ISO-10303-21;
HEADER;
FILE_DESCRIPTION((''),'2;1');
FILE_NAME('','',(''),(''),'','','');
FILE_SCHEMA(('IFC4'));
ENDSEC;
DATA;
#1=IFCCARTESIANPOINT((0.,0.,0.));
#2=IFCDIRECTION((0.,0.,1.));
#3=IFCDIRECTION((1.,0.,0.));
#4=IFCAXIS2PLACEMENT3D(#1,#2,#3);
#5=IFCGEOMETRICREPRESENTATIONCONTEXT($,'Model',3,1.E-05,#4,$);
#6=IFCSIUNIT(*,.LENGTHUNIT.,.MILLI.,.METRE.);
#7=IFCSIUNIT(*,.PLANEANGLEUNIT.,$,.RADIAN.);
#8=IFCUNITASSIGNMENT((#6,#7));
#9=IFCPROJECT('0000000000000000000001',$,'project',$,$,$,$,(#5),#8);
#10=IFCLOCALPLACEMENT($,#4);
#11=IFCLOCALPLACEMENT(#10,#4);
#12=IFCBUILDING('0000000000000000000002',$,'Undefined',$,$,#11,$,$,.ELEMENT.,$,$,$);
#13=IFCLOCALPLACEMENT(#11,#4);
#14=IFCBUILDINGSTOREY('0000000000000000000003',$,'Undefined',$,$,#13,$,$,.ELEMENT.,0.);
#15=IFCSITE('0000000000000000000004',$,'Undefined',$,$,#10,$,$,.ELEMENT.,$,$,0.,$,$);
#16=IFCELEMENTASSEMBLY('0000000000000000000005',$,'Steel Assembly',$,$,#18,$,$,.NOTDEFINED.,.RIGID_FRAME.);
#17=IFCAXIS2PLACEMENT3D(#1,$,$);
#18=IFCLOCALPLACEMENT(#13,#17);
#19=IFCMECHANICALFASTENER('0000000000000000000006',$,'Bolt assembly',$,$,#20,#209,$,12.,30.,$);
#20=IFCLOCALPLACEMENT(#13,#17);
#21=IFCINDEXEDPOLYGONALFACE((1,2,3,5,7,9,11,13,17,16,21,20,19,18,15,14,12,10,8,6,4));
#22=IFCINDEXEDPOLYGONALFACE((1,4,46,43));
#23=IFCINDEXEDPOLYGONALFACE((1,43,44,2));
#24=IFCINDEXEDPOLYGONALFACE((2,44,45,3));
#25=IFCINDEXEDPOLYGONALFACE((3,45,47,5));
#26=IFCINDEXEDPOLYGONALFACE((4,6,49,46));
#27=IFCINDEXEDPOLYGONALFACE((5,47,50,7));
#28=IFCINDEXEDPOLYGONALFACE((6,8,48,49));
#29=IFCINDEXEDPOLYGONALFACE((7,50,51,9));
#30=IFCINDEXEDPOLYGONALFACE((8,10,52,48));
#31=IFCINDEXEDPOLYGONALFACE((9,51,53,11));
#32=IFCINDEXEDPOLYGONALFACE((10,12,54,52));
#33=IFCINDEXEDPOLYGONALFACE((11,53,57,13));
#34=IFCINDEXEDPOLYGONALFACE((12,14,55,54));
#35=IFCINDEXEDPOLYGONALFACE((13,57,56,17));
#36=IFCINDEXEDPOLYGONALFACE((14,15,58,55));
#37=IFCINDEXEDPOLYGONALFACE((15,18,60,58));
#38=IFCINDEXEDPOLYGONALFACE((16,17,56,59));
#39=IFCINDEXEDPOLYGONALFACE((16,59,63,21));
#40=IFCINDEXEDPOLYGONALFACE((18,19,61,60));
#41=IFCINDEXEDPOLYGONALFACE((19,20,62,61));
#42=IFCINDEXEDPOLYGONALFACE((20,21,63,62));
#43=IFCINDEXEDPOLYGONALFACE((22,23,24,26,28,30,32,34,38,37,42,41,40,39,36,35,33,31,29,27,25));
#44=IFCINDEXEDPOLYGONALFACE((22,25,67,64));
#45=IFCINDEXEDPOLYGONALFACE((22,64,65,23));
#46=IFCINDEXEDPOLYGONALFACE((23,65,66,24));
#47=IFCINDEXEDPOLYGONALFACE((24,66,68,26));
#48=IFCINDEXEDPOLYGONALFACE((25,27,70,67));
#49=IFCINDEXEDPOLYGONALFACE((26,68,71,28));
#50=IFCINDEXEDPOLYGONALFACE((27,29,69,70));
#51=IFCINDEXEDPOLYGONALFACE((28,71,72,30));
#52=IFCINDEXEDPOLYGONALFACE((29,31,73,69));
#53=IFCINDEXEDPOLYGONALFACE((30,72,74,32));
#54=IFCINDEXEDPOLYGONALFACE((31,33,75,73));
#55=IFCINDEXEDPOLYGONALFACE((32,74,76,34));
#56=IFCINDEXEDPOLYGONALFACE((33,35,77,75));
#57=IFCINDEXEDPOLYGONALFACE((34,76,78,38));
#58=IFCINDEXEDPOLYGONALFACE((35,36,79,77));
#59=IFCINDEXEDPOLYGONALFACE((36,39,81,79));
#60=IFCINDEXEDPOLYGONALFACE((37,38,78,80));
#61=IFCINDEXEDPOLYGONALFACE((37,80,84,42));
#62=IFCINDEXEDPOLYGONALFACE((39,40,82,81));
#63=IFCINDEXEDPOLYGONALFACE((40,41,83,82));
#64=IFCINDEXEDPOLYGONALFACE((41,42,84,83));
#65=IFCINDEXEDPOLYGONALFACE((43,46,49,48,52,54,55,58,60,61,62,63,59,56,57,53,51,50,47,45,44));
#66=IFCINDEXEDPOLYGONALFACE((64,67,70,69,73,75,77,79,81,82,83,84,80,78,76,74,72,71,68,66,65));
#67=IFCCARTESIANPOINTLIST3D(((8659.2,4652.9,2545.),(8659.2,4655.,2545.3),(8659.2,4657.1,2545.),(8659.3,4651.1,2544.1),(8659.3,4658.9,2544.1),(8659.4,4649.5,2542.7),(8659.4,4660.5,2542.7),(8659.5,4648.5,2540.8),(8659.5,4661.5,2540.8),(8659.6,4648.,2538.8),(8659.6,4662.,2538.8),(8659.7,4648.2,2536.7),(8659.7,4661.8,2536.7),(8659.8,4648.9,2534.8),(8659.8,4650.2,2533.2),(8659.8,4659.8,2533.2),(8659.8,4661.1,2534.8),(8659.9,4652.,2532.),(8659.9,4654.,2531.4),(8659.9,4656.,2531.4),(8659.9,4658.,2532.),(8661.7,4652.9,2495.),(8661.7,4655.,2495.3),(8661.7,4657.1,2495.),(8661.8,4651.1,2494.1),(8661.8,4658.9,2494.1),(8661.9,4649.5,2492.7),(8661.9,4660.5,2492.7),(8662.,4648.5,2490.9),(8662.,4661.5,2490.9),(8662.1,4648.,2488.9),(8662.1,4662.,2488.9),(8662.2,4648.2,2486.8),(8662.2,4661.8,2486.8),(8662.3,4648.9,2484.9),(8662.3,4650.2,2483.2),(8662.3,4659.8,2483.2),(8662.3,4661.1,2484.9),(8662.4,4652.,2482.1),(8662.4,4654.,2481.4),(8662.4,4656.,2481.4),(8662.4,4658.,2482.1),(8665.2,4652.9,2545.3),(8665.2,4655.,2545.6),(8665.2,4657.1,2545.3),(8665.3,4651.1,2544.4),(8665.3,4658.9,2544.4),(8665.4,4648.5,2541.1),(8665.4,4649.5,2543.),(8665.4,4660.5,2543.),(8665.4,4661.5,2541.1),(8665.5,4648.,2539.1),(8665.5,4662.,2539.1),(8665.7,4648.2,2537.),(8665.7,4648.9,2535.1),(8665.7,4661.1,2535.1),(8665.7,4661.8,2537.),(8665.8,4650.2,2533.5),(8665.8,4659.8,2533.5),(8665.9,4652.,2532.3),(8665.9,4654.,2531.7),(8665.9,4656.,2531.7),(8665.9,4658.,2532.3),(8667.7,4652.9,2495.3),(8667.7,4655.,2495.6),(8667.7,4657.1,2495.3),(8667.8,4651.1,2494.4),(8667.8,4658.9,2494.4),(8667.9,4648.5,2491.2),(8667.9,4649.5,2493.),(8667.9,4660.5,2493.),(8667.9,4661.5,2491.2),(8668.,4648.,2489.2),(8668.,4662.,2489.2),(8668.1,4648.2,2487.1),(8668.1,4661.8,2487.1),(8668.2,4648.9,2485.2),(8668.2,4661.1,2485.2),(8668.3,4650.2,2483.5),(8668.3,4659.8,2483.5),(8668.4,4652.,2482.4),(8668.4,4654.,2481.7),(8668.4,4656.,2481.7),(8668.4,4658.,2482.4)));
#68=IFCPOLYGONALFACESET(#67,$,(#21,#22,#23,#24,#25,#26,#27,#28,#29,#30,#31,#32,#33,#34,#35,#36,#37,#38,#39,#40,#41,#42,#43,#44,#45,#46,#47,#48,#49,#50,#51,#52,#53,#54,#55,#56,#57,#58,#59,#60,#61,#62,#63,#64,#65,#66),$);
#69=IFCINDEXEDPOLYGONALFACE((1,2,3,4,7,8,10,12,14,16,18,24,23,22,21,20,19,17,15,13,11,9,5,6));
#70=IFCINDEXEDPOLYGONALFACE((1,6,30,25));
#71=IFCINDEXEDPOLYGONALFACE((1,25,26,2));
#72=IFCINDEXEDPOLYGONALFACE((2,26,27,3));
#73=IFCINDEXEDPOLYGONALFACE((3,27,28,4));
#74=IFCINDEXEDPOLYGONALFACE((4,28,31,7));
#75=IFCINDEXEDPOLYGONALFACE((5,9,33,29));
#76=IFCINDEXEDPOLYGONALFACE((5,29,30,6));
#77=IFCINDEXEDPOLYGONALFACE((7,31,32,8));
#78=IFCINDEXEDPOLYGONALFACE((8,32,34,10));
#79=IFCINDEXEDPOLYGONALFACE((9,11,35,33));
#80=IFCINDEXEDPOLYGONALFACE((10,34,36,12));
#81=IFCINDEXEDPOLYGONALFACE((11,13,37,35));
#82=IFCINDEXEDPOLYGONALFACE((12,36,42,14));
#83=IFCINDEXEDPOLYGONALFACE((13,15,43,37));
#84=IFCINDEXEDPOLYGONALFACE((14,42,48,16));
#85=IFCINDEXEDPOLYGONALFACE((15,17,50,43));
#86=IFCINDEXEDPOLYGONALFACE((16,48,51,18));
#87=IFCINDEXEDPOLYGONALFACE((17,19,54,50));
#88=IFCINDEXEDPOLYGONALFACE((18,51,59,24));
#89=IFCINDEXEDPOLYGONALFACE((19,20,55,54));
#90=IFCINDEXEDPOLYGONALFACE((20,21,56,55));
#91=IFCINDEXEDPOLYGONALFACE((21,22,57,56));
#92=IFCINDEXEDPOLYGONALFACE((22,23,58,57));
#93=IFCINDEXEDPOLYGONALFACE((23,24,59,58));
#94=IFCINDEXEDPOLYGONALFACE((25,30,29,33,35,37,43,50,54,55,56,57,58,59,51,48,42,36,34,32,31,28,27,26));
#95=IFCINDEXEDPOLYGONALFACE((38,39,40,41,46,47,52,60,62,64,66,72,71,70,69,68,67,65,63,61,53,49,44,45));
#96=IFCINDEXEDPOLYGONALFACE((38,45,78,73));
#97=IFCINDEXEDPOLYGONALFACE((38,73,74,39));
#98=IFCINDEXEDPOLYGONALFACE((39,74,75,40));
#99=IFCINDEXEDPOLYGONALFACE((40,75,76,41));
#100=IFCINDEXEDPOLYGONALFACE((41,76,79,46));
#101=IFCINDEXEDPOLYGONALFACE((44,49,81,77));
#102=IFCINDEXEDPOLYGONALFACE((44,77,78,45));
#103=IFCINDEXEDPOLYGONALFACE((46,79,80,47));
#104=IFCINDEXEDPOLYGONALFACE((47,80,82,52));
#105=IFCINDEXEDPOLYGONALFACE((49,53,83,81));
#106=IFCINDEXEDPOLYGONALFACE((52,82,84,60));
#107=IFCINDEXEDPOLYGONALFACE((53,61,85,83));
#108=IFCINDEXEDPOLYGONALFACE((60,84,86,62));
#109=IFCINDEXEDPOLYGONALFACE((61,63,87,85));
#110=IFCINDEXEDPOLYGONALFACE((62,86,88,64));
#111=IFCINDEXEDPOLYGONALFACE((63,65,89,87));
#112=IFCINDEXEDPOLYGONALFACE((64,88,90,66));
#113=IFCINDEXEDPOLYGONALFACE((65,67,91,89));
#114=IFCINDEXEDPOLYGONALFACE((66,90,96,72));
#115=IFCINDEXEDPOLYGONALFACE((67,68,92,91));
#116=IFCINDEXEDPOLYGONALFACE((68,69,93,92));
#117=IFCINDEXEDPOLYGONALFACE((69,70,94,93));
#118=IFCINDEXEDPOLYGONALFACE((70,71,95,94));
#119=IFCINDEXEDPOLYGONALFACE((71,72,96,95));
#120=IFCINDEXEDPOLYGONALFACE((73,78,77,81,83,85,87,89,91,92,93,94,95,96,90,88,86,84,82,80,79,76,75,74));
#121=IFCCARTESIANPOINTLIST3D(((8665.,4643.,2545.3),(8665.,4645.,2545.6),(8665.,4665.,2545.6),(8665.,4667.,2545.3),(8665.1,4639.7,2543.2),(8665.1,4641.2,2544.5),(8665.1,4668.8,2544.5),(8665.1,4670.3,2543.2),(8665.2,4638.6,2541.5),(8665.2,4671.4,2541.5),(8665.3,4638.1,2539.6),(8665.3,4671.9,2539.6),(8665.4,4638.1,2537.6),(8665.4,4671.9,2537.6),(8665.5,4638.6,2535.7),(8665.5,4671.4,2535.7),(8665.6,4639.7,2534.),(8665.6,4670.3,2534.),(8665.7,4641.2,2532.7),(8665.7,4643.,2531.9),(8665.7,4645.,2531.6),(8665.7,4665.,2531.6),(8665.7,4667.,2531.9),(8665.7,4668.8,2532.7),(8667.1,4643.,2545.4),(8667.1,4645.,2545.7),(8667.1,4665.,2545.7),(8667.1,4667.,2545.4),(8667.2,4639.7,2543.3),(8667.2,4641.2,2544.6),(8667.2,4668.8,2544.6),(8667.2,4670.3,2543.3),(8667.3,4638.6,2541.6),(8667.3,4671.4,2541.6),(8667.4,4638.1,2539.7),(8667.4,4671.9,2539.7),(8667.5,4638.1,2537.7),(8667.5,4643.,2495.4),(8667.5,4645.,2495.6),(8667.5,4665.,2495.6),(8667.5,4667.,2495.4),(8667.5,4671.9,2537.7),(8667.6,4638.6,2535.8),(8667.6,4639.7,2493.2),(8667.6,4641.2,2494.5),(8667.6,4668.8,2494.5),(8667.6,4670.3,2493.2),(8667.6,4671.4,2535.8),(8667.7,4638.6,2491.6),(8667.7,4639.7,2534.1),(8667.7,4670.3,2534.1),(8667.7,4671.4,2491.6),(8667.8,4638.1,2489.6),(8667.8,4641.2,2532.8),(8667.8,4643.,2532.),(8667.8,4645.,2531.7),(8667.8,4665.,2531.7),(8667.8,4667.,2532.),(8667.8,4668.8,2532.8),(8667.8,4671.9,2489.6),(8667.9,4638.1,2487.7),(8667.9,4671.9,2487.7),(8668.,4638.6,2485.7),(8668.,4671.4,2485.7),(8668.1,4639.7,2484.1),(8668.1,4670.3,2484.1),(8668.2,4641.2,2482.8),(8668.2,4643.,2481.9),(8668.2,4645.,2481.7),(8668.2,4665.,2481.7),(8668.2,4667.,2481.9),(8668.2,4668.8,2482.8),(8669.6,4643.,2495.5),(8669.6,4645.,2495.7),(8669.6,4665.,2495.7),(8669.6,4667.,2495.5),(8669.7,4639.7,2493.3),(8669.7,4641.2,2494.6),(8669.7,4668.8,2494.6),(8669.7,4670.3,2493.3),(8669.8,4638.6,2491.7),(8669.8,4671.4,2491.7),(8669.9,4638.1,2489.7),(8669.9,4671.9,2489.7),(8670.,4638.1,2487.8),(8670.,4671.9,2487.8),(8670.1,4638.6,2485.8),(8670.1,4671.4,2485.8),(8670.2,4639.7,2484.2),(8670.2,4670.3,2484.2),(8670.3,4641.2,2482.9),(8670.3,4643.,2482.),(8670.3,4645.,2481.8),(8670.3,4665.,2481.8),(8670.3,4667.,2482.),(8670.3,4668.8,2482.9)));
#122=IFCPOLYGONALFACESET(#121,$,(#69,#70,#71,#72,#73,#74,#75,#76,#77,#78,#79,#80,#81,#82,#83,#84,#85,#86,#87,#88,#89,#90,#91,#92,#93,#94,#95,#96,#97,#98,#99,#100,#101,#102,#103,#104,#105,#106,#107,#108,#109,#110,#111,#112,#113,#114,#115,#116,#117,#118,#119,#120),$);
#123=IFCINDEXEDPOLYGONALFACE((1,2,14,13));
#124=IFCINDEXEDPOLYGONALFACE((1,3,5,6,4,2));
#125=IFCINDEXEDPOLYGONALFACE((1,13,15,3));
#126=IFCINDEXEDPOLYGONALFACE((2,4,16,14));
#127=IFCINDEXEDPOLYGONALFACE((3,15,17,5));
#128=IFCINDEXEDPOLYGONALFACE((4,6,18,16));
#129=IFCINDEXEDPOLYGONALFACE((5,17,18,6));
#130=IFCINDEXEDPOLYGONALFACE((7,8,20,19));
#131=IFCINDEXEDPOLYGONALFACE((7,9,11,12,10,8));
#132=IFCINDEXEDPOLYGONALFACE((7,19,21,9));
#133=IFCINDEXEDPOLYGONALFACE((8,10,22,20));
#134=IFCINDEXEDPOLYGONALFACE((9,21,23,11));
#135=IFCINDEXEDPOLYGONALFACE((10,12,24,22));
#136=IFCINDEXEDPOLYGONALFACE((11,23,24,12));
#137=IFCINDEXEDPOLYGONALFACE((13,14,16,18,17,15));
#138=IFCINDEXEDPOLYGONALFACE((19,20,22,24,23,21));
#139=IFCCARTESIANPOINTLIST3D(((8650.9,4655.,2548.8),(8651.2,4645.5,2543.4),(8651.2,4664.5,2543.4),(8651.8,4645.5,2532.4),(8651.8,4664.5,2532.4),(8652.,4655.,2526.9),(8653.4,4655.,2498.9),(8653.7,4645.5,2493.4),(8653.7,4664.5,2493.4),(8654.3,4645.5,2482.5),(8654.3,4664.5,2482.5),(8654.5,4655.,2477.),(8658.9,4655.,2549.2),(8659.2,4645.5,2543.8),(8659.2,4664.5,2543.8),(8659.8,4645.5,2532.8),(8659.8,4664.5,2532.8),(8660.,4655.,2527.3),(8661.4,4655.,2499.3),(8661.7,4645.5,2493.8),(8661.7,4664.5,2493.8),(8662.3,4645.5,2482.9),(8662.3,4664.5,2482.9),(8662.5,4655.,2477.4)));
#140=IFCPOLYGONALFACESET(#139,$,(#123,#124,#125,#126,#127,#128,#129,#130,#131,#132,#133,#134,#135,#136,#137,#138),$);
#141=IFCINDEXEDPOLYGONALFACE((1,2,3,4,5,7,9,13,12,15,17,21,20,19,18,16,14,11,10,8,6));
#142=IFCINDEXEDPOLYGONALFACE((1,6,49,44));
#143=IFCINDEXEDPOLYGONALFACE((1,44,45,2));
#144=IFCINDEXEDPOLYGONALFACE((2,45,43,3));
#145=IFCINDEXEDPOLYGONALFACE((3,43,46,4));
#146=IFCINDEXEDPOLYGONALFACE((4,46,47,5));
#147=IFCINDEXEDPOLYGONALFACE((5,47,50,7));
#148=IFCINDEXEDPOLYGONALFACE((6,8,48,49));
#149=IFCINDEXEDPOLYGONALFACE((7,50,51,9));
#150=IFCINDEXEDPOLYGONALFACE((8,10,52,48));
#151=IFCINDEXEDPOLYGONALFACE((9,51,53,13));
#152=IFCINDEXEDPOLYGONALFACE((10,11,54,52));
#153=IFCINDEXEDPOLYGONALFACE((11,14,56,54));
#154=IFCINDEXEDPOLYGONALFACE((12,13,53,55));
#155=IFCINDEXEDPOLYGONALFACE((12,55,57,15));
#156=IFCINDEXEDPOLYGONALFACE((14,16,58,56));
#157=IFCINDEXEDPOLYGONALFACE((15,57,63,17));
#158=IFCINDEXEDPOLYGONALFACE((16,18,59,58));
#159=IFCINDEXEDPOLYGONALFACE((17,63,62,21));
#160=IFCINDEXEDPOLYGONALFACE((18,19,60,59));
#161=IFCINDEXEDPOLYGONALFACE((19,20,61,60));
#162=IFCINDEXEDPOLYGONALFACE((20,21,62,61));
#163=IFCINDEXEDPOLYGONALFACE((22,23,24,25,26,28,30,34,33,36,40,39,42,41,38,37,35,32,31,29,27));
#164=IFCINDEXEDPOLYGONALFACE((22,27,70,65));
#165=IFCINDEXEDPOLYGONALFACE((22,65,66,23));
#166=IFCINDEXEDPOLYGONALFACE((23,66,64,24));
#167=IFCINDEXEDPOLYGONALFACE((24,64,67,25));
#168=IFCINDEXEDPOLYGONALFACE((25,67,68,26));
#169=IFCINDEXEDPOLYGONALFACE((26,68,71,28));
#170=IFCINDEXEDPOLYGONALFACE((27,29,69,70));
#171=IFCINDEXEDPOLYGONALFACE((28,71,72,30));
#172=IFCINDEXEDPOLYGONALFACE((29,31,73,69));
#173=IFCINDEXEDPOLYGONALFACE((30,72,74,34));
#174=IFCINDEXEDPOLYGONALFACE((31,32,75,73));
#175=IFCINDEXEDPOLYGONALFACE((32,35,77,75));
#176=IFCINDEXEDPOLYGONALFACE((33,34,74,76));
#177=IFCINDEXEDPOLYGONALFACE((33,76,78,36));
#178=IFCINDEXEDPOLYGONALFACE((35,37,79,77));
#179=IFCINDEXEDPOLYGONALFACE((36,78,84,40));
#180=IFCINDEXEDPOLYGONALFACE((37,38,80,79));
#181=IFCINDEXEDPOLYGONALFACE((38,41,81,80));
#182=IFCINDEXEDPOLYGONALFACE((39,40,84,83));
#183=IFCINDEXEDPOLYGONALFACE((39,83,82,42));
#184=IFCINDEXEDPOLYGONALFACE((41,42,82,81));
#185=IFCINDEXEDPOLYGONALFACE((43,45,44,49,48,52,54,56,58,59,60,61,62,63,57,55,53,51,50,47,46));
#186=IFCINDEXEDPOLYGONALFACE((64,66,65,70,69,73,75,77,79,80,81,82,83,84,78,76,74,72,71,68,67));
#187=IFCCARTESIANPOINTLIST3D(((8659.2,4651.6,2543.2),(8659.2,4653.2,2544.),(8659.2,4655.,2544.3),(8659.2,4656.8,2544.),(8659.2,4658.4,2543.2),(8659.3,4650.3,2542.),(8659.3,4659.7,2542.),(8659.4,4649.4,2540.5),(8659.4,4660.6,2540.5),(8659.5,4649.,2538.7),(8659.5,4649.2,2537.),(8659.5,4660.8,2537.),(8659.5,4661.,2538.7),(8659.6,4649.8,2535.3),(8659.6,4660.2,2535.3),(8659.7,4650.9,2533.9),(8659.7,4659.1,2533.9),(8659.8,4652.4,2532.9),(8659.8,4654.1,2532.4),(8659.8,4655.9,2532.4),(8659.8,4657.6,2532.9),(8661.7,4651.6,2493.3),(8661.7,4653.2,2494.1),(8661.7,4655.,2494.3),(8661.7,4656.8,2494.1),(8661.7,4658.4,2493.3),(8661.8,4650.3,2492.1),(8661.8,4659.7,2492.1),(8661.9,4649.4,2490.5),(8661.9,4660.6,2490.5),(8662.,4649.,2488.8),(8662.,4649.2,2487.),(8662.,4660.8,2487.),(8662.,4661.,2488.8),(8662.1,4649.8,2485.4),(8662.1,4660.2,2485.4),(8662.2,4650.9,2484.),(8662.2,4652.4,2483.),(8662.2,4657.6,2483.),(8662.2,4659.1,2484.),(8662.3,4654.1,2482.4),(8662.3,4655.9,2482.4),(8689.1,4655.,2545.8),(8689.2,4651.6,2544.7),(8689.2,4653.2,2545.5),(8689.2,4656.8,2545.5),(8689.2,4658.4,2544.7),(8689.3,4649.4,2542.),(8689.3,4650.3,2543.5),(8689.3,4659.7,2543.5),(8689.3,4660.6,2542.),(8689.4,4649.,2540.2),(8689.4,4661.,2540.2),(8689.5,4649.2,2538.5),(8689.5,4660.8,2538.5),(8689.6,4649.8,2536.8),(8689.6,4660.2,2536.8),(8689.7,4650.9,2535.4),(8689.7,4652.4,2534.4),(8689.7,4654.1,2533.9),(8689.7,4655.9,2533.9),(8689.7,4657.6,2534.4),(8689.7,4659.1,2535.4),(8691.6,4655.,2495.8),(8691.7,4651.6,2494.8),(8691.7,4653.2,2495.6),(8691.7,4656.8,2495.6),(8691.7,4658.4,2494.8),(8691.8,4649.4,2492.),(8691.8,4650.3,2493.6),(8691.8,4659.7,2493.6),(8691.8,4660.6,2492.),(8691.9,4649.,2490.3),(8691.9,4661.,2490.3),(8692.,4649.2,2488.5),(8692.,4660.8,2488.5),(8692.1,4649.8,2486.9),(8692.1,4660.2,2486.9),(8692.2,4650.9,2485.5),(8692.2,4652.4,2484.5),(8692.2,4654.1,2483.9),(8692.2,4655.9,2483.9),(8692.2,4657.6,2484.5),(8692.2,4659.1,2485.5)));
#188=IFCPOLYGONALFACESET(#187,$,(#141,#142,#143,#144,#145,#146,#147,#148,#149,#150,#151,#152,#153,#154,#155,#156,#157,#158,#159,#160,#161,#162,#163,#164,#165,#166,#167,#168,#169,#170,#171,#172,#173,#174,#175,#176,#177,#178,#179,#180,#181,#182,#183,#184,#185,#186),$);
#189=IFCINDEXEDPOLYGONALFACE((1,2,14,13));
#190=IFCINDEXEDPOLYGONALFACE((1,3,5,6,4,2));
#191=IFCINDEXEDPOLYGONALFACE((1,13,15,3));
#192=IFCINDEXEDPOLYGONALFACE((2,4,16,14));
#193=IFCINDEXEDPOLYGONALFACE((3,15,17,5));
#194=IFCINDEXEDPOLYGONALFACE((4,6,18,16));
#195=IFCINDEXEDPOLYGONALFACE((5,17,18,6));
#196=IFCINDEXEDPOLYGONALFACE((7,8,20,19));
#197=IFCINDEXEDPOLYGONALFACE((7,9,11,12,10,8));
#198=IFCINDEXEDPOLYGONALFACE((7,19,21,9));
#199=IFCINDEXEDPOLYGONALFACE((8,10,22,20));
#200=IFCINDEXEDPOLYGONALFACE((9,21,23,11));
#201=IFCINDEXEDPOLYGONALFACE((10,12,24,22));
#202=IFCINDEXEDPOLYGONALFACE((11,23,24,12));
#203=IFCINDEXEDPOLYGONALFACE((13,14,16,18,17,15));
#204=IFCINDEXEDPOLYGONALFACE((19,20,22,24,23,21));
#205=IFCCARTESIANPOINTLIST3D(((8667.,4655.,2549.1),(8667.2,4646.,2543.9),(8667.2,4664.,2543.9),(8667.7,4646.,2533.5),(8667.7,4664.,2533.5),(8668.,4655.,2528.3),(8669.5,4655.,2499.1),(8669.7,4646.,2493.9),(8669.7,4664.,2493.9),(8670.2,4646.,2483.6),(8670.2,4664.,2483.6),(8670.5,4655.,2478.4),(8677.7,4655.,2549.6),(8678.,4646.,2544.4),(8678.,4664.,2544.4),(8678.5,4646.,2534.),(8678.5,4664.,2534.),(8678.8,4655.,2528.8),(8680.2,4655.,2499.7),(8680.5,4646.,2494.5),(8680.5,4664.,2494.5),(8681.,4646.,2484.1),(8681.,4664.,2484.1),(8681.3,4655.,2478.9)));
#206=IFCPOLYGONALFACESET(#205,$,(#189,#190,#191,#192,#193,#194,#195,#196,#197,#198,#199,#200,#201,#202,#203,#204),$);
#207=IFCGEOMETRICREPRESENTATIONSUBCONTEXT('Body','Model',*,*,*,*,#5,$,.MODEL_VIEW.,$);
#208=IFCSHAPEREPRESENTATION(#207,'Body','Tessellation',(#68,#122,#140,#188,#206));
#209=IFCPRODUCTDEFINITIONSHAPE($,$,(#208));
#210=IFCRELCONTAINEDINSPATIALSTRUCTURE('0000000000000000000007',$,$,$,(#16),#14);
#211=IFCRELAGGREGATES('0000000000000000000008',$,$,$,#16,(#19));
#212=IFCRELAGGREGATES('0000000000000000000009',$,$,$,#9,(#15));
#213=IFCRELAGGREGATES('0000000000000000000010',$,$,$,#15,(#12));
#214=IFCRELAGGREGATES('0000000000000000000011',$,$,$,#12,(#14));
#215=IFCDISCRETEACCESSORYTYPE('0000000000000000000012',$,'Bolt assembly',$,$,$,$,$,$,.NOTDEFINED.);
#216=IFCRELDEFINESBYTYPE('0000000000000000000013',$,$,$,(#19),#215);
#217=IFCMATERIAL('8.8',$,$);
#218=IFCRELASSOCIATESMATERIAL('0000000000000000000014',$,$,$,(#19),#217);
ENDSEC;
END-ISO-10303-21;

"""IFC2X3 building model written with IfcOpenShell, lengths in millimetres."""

from ifc_helpers import new_model, si_unit, frame, frame_2d, origin_with_axes, origin_2d_with_axis, place, context, subcontext, project, spatial, polyline, circle_curve, parameter, trimmed, segment, composite_curve, circle, outline, extrude, source, transform, mapped, material, type_object, element, aggregate, save


model = new_model("IFC2X3")

# Units and contexts
model_context = context("Model", 3, precision=1e-05, world=origin_with_axes())
body_context = subcontext(model_context, "Body", "Model", "MODEL_VIEW")
ifc_project = project(units=[si_unit("LENGTHUNIT", "METRE", prefix="MILLI"), si_unit("PLANEANGLEUNIT", "RADIAN")], contexts=[model_context])

# Site, building, storey
site_placement = place(None, origin_with_axes())
site = spatial("IfcSite", under=ifc_project, at=site_placement, Name="Undefined", CompositionType="ELEMENT", RefElevation=0.0)
building_placement = place(site_placement, origin_with_axes())
building = spatial("IfcBuilding", under=site, at=building_placement, Name="Undefined", CompositionType="ELEMENT")
storey_placement = place(building_placement, origin_with_axes())
storey = spatial("IfcBuildingStorey", under=building, at=storey_placement, Name="Undefined", CompositionType="ELEMENT", Elevation=0.0)

# Element assembly
assembly_1_placement = place(storey_placement, origin_with_axes())
assembly_1 = element("IfcElementAssembly", 1, at=assembly_1_placement, inside=storey, Name="Steel Assembly", AssemblyPlace="NOTDEFINED", PredefinedType="RIGID_FRAME")

# Mechanical fastener
discrete_accessory_type_1 = type_object("IfcDiscreteAccessoryType", Name="Bolt assembly")
ifc_material_1 = material(Name="8.8")
shared_shape_1 = source(origin_with_axes(), body_context, "Body", "SweptSolid", [
    extrude(circle(Radius=7.0, at=origin_2d_with_axis()), frame((0.0, -2.9, 0.0), z_axis=(0.0, 1.0, 0.0), x_axis=(1.0, 0.0, 0.0)), (0.0, 0.0, 1.0), 6.0),
    extrude(outline(composite_curve([segment(polyline([(7.0, 10.0), (7.0, -10.0)]), True, "CONTINUOUS"), segment(trimmed(circle_curve(frame_2d((0.0, -10.0), x_axis=(1.0, 0.0)), 7.0), [parameter(0.0)], [parameter(3.1416)], False, "PARAMETER"), True, "CONTINUOUS"), segment(polyline([(-7.0, -10.0), (-7.0, 10.0)]), True, "CONTINUOUS"), segment(trimmed(circle_curve(frame_2d((0.0, 10.0), x_axis=(-1.0, 0.0)), 7.0), [parameter(0.0)], [parameter(3.1416)], False, "PARAMETER"), True, "DISCONTINUOUS")], self_intersect=False)), frame((0.0, 2.9, 0.0), z_axis=(0.0, 1.0, 0.0), x_axis=(1.0, 0.0, 0.0)), (0.0, 0.0, 1.0), 2.1),
    extrude(outline(polyline([(11.0, 0.0), (5.5, 9.5), (-5.5, 9.5), (-11.0, 0.0), (-5.5, -9.5), (5.5, -9.5), (11.0, 0.0)])), frame((0.0, -11.0, 0.0), z_axis=(0.0, 1.0, 0.0), x_axis=(1.0, 0.0, 0.0)), (0.0, 0.0, 1.0), 8.0),
    extrude(circle(Radius=6.0, at=origin_2d_with_axis()), frame((0.0, -3.0, 0.0), z_axis=(0.0, 1.0, 0.0), x_axis=(1.0, 0.0, 0.0)), (0.0, 0.0, 1.0), 30.0),
    extrude(outline(polyline([(10.4, 0.0), (5.2, 9.0), (-5.2, 9.0), (-10.4, 0.0), (-5.2, -9.0), (5.2, -9.0), (10.4, 0.0)])), frame((0.0, 5.0, 0.0), z_axis=(0.0, 1.0, 0.0), x_axis=(1.0, 0.0, 0.0)), (0.0, 0.0, 1.0), 10.8),
])
mechanical_fastener_1_placement = place(assembly_1_placement, frame((8666.2, 4610.0, 2463.5), z_axis=(0.0, 1.0, 0.0), x_axis=(-0.049938, 0.0, 0.998752)))
mechanical_fastener_1 = element("IfcMechanicalFastener", 2, at=mechanical_fastener_1_placement, type_object=discrete_accessory_type_1, material=ifc_material_1, Name="Bolt assembly", NominalDiameter=12.0, NominalLength=30.0, context=body_context, shape_type="MappedRepresentation", body=[
    mapped(shared_shape_1, transform((25.0, 0.0, 45.0))),
    mapped(shared_shape_1, transform((75.0, 0.0, 45.0))),
])
aggregate(assembly_1, [mechanical_fastener_1])

save(model, "model.ifc")
